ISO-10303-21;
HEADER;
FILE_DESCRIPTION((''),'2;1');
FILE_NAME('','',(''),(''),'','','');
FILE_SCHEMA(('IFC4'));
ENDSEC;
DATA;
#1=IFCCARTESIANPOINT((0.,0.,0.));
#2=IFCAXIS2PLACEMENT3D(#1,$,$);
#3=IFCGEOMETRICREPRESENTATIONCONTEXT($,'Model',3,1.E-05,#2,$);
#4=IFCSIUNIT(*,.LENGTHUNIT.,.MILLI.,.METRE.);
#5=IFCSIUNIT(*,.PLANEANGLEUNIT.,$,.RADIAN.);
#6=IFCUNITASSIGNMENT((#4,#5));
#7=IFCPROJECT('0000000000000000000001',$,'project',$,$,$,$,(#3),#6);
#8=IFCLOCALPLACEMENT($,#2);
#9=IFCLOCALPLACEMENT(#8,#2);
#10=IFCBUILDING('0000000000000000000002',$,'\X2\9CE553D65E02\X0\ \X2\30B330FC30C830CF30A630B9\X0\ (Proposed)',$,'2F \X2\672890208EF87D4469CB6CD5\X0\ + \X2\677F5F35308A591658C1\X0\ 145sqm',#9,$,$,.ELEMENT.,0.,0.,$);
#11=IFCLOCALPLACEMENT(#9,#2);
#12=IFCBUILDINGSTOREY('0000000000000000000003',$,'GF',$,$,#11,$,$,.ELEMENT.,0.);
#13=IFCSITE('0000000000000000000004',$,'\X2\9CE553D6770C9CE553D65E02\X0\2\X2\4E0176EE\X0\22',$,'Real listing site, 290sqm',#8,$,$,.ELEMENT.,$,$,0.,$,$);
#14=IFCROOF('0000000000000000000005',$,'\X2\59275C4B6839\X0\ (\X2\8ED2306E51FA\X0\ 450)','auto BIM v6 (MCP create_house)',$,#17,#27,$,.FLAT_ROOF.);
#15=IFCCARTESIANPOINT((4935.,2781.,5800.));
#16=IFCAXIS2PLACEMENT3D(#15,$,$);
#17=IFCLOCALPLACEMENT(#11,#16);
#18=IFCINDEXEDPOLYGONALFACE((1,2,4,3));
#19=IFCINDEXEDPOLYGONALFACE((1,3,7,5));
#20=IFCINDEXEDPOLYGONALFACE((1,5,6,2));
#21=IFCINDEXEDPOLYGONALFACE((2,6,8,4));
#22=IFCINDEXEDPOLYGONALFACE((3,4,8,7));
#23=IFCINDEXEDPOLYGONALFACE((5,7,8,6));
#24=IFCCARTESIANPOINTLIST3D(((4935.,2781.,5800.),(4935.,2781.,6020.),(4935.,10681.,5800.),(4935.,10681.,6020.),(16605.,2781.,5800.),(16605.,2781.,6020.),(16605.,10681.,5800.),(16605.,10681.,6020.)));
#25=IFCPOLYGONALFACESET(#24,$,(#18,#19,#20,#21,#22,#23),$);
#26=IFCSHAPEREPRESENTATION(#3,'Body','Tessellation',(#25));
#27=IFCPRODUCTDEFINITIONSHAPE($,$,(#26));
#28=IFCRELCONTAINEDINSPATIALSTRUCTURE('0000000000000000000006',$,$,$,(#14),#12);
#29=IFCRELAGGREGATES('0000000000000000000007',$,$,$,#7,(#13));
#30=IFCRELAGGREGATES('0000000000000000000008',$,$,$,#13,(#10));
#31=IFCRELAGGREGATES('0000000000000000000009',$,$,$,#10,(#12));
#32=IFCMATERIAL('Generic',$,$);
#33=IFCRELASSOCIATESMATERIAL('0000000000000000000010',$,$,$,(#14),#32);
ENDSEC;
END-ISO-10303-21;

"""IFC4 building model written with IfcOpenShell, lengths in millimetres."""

from ifc_helpers import new_model, si_unit, frame, frame_2d, origin, place, context, project, spatial, rectangle, extrude, material, element, save


model = new_model("IFC4")

# Units and contexts
model_context = context("Model", 3, precision=1e-05, world=origin())
ifc_project = project(units=[si_unit("LENGTHUNIT", "METRE", prefix="MILLI"), si_unit("PLANEANGLEUNIT", "RADIAN")], contexts=[model_context])

# Site, building, storey
site_placement = place(None, origin())
site = spatial("IfcSite", under=ifc_project, at=site_placement, Name="鳥取県鳥取市2丁目22", ObjectType="Real listing site, 290sqm", CompositionType="ELEMENT", RefElevation=0.0)
building_placement = place(site_placement, origin())
building = spatial("IfcBuilding", under=site, at=building_placement, Name="鳥取市 コートハウス (Proposed)", ObjectType="2F 木造軸組構法 + 板張り外壁 145sqm", CompositionType="ELEMENT", ElevationOfRefHeight=0.0, ElevationOfTerrain=0.0)
storey_placement = place(building_placement, origin())
storey = spatial("IfcBuildingStorey", under=building, at=storey_placement, Name="GF", CompositionType="ELEMENT", Elevation=0.0)

# Shared definitions
ifc_material = material(Name="Generic")

# Roof
roof_placement = place(storey_placement, frame((4935.0, 2781.0, 5800.0)))
element("IfcRoof", 1, at=roof_placement, inside=storey, material=ifc_material, Name="大屋根 (軒の出 450)", Description="auto BIM v6 (MCP create_house)", PredefinedType="FLAT_ROOF", context=model_context, shape_type="SweptSolid", body=[
    extrude(rectangle(XDim=11670.0, YDim=7900.0, at=frame_2d((5835.0, 3950.0))), frame((4935.0, 2781.0, 5800.0)), (0.0, 0.0, 1.0), 220.0),
])

save(model, "model.ifc")
